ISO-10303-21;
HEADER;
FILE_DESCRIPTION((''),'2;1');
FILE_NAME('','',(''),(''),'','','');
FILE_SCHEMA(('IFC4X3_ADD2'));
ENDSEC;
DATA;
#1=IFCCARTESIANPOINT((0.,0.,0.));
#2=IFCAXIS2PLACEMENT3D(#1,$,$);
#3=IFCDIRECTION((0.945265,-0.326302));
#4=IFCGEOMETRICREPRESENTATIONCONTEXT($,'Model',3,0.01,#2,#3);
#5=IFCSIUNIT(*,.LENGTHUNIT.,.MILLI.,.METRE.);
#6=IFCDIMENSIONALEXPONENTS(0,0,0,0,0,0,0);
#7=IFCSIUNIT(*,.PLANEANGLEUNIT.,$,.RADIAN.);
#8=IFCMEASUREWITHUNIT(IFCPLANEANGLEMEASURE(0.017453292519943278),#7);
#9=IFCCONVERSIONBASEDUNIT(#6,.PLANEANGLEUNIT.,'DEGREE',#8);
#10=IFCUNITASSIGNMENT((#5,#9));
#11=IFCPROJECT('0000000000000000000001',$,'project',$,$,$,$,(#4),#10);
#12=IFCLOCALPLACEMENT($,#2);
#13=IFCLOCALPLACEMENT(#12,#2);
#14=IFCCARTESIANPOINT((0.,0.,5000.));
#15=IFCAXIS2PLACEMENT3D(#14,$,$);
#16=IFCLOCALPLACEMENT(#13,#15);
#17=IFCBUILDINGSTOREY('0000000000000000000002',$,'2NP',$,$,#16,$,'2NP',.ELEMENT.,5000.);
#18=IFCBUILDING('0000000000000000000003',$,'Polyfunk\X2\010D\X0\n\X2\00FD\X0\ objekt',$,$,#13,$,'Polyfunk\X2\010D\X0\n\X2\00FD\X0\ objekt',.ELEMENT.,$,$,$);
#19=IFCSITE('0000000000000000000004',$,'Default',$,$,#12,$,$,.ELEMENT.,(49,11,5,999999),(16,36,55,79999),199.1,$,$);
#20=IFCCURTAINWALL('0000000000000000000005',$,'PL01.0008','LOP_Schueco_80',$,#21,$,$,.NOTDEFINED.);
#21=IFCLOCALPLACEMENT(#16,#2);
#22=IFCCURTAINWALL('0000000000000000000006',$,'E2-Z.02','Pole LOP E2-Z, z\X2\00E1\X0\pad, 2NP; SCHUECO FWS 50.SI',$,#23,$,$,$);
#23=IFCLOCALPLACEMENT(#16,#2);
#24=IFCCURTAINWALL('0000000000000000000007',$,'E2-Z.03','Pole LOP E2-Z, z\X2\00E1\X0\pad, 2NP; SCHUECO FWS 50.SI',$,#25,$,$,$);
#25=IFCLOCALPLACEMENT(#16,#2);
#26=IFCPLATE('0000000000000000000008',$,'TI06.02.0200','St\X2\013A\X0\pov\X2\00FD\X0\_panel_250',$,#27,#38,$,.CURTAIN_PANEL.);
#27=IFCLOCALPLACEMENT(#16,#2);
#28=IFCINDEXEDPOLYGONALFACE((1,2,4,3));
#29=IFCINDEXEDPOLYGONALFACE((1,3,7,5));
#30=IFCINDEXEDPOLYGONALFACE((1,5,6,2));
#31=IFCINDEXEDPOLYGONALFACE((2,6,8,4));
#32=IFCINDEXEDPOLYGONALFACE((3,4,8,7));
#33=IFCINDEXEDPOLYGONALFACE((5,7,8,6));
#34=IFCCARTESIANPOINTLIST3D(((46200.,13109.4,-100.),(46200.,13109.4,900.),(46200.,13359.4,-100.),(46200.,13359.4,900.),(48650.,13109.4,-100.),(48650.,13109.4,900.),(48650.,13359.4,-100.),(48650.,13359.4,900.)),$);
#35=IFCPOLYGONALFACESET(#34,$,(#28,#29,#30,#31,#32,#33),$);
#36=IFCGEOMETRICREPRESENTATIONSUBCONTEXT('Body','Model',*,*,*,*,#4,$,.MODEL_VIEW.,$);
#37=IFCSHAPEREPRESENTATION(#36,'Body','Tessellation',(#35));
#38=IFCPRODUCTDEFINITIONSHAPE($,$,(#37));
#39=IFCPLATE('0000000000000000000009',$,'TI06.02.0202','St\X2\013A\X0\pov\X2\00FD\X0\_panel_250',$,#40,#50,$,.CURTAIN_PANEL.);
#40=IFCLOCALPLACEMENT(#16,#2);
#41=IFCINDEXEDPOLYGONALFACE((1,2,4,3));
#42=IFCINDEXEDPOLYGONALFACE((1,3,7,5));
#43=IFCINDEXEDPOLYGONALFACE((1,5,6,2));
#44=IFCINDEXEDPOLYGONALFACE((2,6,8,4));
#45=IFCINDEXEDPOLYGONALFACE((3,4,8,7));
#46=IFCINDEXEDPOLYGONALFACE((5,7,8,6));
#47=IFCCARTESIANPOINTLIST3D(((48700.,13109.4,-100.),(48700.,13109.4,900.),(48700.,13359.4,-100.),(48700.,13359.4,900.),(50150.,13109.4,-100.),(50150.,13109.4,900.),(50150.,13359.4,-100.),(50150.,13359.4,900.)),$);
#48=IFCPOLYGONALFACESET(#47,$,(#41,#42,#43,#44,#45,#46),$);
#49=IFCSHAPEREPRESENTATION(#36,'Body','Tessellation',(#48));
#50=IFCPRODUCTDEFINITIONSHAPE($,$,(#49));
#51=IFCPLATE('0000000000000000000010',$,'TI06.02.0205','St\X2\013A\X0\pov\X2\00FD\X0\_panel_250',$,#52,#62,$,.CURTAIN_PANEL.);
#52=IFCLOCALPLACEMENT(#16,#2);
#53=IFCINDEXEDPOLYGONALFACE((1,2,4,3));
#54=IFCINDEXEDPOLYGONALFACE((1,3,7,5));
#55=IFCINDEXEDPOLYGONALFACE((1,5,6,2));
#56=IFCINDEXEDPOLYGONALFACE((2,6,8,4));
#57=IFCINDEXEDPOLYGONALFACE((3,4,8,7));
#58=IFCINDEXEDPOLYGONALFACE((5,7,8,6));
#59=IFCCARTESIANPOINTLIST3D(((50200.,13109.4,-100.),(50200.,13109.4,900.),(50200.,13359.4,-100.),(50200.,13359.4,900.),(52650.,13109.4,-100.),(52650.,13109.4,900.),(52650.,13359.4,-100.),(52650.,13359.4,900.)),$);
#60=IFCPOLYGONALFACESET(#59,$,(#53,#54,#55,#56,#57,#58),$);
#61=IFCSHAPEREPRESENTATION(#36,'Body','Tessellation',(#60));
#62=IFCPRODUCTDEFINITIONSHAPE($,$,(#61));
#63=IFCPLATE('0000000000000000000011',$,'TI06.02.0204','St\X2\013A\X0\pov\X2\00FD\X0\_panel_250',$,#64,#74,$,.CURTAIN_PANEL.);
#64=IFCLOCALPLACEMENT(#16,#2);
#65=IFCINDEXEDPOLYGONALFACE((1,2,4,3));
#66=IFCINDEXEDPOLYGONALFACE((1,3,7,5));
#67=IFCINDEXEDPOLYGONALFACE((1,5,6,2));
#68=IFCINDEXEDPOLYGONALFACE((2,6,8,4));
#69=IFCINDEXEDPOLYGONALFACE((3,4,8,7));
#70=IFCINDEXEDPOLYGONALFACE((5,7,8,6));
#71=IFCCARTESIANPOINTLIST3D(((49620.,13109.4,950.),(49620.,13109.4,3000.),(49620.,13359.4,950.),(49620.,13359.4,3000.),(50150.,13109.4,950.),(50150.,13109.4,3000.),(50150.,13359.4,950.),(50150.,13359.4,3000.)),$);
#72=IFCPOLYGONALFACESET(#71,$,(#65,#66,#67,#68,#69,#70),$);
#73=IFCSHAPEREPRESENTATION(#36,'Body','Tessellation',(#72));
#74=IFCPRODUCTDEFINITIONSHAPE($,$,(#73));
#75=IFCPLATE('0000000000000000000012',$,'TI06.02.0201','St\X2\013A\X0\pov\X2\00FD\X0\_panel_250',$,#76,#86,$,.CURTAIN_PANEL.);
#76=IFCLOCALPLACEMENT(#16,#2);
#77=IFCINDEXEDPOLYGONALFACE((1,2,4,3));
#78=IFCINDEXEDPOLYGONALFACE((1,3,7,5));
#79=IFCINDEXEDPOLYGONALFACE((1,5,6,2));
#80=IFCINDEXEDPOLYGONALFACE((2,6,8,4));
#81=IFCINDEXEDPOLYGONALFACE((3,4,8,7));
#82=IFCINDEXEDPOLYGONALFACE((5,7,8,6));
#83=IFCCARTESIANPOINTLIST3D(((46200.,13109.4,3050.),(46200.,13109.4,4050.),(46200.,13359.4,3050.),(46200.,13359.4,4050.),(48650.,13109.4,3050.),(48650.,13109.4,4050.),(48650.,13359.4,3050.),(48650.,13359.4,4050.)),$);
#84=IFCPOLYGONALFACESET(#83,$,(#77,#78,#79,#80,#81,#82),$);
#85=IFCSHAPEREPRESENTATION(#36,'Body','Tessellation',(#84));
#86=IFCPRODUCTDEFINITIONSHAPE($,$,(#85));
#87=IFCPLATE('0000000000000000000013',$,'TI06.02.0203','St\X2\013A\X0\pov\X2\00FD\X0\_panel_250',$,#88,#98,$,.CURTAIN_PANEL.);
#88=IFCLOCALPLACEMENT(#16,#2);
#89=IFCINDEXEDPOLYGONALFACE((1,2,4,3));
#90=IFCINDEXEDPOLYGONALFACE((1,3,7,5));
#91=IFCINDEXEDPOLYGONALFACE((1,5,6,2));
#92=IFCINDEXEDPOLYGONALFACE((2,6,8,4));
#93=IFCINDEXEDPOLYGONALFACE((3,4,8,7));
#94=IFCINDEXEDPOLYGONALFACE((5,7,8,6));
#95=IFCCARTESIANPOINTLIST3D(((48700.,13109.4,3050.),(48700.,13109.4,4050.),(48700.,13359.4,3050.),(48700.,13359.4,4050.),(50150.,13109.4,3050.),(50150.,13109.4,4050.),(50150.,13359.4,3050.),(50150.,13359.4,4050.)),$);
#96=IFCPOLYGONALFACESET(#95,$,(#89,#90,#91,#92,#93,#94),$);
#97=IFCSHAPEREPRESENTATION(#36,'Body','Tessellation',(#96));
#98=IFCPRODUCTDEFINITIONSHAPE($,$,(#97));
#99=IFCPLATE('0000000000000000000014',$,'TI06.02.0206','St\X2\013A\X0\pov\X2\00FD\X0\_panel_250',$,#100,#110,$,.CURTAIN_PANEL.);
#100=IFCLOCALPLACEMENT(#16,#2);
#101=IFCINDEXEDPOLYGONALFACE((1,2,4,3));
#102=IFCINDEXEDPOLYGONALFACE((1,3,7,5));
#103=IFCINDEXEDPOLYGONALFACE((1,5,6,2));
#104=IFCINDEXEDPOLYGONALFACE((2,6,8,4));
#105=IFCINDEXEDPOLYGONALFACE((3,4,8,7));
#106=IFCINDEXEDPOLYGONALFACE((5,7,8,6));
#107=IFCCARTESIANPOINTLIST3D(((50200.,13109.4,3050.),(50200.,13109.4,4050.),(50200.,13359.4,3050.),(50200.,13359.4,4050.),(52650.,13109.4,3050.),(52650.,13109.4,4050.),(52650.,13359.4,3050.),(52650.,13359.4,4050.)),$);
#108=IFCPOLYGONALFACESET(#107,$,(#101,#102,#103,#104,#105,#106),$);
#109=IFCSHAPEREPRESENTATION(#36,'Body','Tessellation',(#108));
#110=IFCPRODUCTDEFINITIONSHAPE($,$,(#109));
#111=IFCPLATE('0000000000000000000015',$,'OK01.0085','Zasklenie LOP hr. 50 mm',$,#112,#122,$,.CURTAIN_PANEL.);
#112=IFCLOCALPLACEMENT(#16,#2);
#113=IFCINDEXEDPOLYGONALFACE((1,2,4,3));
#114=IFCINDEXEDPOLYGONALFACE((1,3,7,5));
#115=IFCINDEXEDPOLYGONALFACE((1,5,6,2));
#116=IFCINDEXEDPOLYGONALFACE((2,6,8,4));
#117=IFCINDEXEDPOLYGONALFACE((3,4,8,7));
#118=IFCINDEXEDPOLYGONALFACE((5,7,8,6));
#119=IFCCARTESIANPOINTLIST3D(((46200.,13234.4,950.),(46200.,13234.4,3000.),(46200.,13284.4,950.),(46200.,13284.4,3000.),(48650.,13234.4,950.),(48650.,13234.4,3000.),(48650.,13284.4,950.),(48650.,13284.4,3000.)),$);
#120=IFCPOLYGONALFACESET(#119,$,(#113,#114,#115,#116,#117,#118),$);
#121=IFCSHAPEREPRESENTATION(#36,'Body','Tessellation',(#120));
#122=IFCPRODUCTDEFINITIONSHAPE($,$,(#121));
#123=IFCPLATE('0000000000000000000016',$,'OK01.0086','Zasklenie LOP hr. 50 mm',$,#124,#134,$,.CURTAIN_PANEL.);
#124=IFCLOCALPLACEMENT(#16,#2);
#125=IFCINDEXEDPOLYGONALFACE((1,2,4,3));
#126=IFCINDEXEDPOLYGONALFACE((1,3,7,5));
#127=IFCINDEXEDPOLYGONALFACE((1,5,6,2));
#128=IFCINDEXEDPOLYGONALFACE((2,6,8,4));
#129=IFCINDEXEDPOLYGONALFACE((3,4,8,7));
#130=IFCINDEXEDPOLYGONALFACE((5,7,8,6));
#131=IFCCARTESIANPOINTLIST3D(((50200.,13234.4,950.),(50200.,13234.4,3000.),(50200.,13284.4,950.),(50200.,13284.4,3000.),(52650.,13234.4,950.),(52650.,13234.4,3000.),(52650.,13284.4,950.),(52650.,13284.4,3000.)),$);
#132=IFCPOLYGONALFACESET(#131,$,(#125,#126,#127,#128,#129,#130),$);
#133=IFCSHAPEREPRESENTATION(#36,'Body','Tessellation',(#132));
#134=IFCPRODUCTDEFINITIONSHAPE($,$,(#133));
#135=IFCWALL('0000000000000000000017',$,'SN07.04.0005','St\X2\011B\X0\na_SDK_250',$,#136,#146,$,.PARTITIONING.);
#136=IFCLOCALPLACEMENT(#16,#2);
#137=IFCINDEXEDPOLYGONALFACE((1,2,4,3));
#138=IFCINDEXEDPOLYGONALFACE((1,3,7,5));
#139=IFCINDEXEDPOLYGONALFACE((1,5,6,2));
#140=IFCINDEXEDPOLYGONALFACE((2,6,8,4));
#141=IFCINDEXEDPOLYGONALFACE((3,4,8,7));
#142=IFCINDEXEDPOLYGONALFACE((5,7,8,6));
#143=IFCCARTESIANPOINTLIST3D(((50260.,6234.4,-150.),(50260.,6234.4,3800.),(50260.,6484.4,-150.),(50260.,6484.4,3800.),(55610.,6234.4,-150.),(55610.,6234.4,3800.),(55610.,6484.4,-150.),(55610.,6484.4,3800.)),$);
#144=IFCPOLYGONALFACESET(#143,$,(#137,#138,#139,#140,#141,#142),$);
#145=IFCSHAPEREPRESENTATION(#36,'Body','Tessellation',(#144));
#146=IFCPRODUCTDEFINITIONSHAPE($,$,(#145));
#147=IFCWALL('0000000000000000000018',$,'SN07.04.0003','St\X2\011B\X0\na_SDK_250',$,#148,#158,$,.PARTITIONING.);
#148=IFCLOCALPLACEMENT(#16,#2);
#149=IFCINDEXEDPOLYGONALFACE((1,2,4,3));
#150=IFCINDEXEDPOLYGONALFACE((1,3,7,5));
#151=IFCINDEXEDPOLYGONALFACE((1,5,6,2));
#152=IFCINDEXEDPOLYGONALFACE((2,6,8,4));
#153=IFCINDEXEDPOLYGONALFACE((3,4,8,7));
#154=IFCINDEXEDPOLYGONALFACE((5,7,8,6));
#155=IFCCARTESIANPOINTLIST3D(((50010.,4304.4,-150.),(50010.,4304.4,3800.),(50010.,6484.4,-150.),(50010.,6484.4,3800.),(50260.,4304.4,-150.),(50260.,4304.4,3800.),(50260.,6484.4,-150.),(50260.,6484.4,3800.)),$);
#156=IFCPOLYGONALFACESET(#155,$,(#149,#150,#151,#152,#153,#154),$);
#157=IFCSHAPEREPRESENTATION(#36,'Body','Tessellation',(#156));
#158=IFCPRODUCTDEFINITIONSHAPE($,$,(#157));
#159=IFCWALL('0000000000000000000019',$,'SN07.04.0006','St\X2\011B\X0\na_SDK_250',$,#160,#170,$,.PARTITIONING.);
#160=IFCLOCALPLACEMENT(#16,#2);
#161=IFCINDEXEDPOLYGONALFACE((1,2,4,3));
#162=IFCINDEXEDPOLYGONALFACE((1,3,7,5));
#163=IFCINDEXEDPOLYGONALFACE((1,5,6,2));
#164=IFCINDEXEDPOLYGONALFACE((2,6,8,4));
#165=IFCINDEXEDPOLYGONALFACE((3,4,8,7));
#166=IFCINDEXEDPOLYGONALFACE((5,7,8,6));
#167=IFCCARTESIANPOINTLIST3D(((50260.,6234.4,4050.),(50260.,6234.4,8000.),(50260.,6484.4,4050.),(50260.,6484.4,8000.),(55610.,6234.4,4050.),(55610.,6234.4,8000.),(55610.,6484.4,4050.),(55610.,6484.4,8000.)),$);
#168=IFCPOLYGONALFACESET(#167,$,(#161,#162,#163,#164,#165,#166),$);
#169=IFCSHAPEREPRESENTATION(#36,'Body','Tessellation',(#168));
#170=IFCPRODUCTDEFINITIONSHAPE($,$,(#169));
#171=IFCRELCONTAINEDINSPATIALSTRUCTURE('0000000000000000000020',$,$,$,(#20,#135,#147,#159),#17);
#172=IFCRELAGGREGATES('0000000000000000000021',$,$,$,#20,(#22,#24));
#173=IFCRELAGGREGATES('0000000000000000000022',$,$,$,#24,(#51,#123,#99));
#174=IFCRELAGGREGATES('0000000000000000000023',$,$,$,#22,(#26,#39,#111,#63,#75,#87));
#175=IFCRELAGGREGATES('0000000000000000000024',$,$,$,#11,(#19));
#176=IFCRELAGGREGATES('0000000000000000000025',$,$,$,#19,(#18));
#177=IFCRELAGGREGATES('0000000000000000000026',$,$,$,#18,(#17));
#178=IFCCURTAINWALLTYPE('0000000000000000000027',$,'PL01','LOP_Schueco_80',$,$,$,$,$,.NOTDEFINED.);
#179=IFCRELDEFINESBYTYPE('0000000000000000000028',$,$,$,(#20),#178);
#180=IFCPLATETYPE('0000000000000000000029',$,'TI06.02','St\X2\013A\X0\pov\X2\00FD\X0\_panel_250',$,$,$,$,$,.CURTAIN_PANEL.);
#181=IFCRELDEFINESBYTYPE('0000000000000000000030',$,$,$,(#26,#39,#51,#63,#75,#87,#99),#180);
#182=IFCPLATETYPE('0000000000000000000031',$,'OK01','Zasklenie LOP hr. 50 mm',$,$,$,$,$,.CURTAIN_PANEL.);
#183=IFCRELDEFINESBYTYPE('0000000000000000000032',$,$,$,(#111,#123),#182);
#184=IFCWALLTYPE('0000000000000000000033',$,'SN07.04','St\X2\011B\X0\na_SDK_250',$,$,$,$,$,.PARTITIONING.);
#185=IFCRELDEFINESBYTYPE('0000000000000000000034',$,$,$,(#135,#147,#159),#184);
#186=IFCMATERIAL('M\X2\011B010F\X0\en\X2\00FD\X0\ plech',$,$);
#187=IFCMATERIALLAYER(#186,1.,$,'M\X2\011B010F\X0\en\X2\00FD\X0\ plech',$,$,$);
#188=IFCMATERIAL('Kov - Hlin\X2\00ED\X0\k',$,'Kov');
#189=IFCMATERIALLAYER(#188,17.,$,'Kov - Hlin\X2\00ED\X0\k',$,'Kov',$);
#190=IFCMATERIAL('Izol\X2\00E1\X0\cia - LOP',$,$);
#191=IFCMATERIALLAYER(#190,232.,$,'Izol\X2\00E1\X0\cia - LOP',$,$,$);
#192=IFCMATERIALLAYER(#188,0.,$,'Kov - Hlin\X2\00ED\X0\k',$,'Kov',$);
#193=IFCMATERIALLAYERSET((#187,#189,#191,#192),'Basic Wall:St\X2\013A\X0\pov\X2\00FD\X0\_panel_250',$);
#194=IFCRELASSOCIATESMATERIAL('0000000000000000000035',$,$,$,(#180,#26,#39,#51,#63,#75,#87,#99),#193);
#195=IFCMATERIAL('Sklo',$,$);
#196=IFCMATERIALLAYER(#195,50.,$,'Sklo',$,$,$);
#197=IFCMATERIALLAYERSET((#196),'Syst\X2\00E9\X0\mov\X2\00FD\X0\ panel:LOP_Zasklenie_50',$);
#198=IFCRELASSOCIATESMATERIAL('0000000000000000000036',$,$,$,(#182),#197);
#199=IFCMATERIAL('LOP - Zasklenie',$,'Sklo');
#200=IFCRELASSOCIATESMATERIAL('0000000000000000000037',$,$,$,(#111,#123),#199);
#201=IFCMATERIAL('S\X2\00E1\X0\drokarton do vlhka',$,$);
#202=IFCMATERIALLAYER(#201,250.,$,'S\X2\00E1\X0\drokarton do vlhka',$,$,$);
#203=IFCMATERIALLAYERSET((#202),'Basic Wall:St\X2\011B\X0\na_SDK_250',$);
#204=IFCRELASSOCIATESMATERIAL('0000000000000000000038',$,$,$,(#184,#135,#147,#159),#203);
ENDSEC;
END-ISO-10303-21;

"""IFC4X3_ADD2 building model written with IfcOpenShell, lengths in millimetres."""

from ifc_helpers import new_model, entity, si_unit, converted_unit, direction, frame, frame_2d, origin, origin_2d_with_axis, place, context, subcontext, project, spatial, polyline, rectangle, extrude, clip, bounded_halfspace, source, transform, mapped, material, layer, layer_set, layer_usage, type_object, type_shapes, element, aggregate, save


model = new_model("IFC4X3_ADD2")

# Units and contexts
model_context = context("Model", 3, precision=0.01, world=origin(), true_north=direction((0.945265, -0.326302)))
body_context = subcontext(model_context, "Body", "Model", "MODEL_VIEW")
ifc_project = project(units=[si_unit("LENGTHUNIT", "METRE", prefix="MILLI"), converted_unit("PLANEANGLEUNIT", "DEGREE", entity("IfcPlaneAngleMeasure", 0.017453292519943278), si_unit("PLANEANGLEUNIT", "RADIAN"), dimensions=[0, 0, 0, 0, 0, 0, 0])], contexts=[model_context])

# Site, building, storey
site_placement = place(None, origin())
site = spatial("IfcSite", under=ifc_project, at=site_placement, Name="Default", CompositionType="ELEMENT", RefLatitude=(49, 11, 5, 999999), RefLongitude=(16, 36, 55, 79999), RefElevation=199.1)
building_placement = place(site_placement, origin())
building = spatial("IfcBuilding", under=site, at=building_placement, Name="Polyfunkčný objekt", LongName="Polyfunkčný objekt", CompositionType="ELEMENT")
storey_placement = place(building_placement, frame((0.0, 0.0, 5000.0)))
storey = spatial("IfcBuildingStorey", under=building, at=storey_placement, Name="2NP", LongName="2NP", CompositionType="ELEMENT", Elevation=5000.0)

# Curtain walls, plates
curtain_wall_type = type_object("IfcCurtainWallType", Name="PL01", Description="LOP_Schueco_80", PredefinedType="NOTDEFINED")
curtain_wall_1_placement = place(storey_placement, frame((0.0, 0.0, -5000.0)))
curtain_wall_1 = element("IfcCurtainWall", 1, at=curtain_wall_1_placement, inside=storey, type_object=curtain_wall_type, Name="PL01.0008", Description="LOP_Schueco_80", PredefinedType="NOTDEFINED")
curtain_wall_2 = element("IfcCurtainWall", 2, Name="E2-Z.02", Description="Pole LOP E2-Z, západ, 2NP; SCHUECO FWS 50.SI")
curtain_wall_3 = element("IfcCurtainWall", 3, Name="E2-Z.03", Description="Pole LOP E2-Z, západ, 2NP; SCHUECO FWS 50.SI")
aggregate(curtain_wall_1, [curtain_wall_2, curtain_wall_3])
ifc_material_1 = material(Name="Měďený plech")
ifc_layer_1 = layer(ifc_material_1, 1.0, Name="Měďený plech")
ifc_material_2 = material(Name="Kov - Hliník", Category="Kov")
ifc_layer_2 = layer(ifc_material_2, 17.0, Name="Kov - Hliník", Category="Kov")
ifc_material_3 = material(Name="Izolácia - LOP")
ifc_layer_3 = layer(ifc_material_3, 232.0, Name="Izolácia - LOP")
ifc_layer_4 = layer(ifc_material_2, 0.0, Name="Kov - Hliník", Category="Kov")
ifc_layer_set_1 = layer_set([ifc_layer_1, ifc_layer_2, ifc_layer_3, ifc_layer_4], Name="Basic Wall:Stĺpový_panel_250")
ifc_layer_usage_1 = layer_usage(ifc_layer_set_1, "AXIS2", "NEGATIVE", 125.0)
plate_type_1 = type_object("IfcPlateType", Name="TI06.02", Description="Stĺpový_panel_250", PredefinedType="CURTAIN_PANEL", material=ifc_layer_set_1)
plate_1_placement = place(storey_placement, frame((46200.0, 13234.4, -100.0)))
plate_1 = element("IfcPlate", 4, at=plate_1_placement, type_object=plate_type_1, material=ifc_layer_usage_1, Name="TI06.02.0200", Description="Stĺpový_panel_250", PredefinedType="CURTAIN_PANEL", context=body_context, shape_type="SweptSolid", body=[
    extrude(rectangle(XDim=250.0, YDim=2450.0, at=frame_2d((0.0, 0.0), x_axis=(1.0, 0.0))), frame((1225.0, 0.0, 0.0), z_axis=(0.0, 0.0, 1.0), x_axis=(0.0, 1.0, 0.0)), (0.0, 0.0, 1.0), 1000.0),
])
ifc_layer_usage_2 = layer_usage(ifc_layer_set_1, "AXIS2", "NEGATIVE", 125.0)
plate_2_placement = place(storey_placement, frame((48700.0, 13234.4, -100.0)))
plate_2 = element("IfcPlate", 5, at=plate_2_placement, type_object=plate_type_1, material=ifc_layer_usage_2, Name="TI06.02.0202", Description="Stĺpový_panel_250", PredefinedType="CURTAIN_PANEL", context=body_context, shape_type="SweptSolid", body=[
    extrude(rectangle(XDim=250.0, YDim=1450.0, at=frame_2d((0.0, 0.0), x_axis=(1.0, 0.0))), frame((725.0, 0.0, 0.0), z_axis=(0.0, 0.0, 1.0), x_axis=(0.0, 1.0, 0.0)), (0.0, 0.0, 1.0), 1000.0),
])
ifc_layer_usage_3 = layer_usage(ifc_layer_set_1, "AXIS2", "NEGATIVE", 125.0)
plate_3_placement = place(storey_placement, frame((50200.0, 13234.4, -100.0)))
plate_3 = element("IfcPlate", 6, at=plate_3_placement, type_object=plate_type_1, material=ifc_layer_usage_3, Name="TI06.02.0205", Description="Stĺpový_panel_250", PredefinedType="CURTAIN_PANEL", context=body_context, shape_type="SweptSolid", body=[
    extrude(rectangle(XDim=250.0, YDim=2450.0, at=origin_2d_with_axis()), frame((1225.0, 0.0, 0.0), z_axis=(0.0, 0.0, 1.0), x_axis=(0.0, 1.0, 0.0)), (0.0, 0.0, 1.0), 1000.0),
])
ifc_layer_usage_4 = layer_usage(ifc_layer_set_1, "AXIS2", "NEGATIVE", 125.0)
plate_4_placement = place(storey_placement, frame((49620.0, 13234.4, 950.0)))
plate_4 = element("IfcPlate", 7, at=plate_4_placement, type_object=plate_type_1, material=ifc_layer_usage_4, Name="TI06.02.0204", Description="Stĺpový_panel_250", PredefinedType="CURTAIN_PANEL", context=body_context, shape_type="SweptSolid", body=[
    extrude(rectangle(XDim=250.0, YDim=530.0, at=frame_2d((0.0, 0.0), x_axis=(1.0, 0.0))), frame((265.0, 0.0, 0.0), z_axis=(0.0, 0.0, 1.0), x_axis=(0.0, 1.0, 0.0)), (0.0, 0.0, 1.0), 2050.0),
])
ifc_layer_usage_5 = layer_usage(ifc_layer_set_1, "AXIS2", "NEGATIVE", 125.0)
plate_5_placement = place(storey_placement, frame((46200.0, 13234.4, 3050.0)))
plate_5 = element("IfcPlate", 8, at=plate_5_placement, type_object=plate_type_1, material=ifc_layer_usage_5, Name="TI06.02.0201", Description="Stĺpový_panel_250", PredefinedType="CURTAIN_PANEL", context=body_context, shape_type="SweptSolid", body=[
    extrude(rectangle(XDim=250.0, YDim=2450.0, at=frame_2d((0.0, 0.0), x_axis=(1.0, 0.0))), frame((1225.0, 0.0, 0.0), z_axis=(0.0, 0.0, 1.0), x_axis=(0.0, 1.0, 0.0)), (0.0, 0.0, 1.0), 1000.0),
])
ifc_layer_usage_6 = layer_usage(ifc_layer_set_1, "AXIS2", "NEGATIVE", 125.0)
plate_6_placement = place(storey_placement, frame((48700.0, 13234.4, 3050.0)))
plate_6 = element("IfcPlate", 9, at=plate_6_placement, type_object=plate_type_1, material=ifc_layer_usage_6, Name="TI06.02.0203", Description="Stĺpový_panel_250", PredefinedType="CURTAIN_PANEL", context=body_context, shape_type="SweptSolid", body=[
    extrude(rectangle(XDim=250.0, YDim=1450.0, at=frame_2d((0.0, 0.0), x_axis=(1.0, 0.0))), frame((725.0, 0.0, 0.0), z_axis=(0.0, 0.0, 1.0), x_axis=(0.0, 1.0, 0.0)), (0.0, 0.0, 1.0), 1000.0),
])
ifc_layer_usage_7 = layer_usage(ifc_layer_set_1, "AXIS2", "NEGATIVE", 125.0)
plate_7_placement = place(storey_placement, frame((50200.0, 13234.4, 3050.0)))
plate_7 = element("IfcPlate", 10, at=plate_7_placement, type_object=plate_type_1, material=ifc_layer_usage_7, Name="TI06.02.0206", Description="Stĺpový_panel_250", PredefinedType="CURTAIN_PANEL", context=body_context, shape_type="SweptSolid", body=[
    extrude(rectangle(XDim=250.0, YDim=2450.0, at=origin_2d_with_axis()), frame((1225.0, 0.0, 0.0), z_axis=(0.0, 0.0, 1.0), x_axis=(0.0, 1.0, 0.0)), (0.0, 0.0, 1.0), 1000.0),
])
ifc_material_4 = material(Name="LOP - Zasklenie", Category="Sklo")
ifc_material_5 = material(Name="Sklo")
ifc_layer_5 = layer(ifc_material_5, 50.0, Name="Sklo")
ifc_layer_set_2 = layer_set([ifc_layer_5], Name="Systémový panel:LOP_Zasklenie_50")
plate_type_2 = type_object("IfcPlateType", Name="OK01", Description="Zasklenie LOP hr. 50 mm", PredefinedType="CURTAIN_PANEL", material=ifc_layer_set_2)
shared_shape_1 = source(origin(), body_context, "Body", "SweptSolid", [
    extrude(rectangle(XDim=50.0, YDim=2450.0, at=origin_2d_with_axis()), frame((0.0, 25.0, 0.0), z_axis=(0.0, 0.0, 1.0), x_axis=(0.0, 1.0, 0.0)), (0.0, 0.0, 1.0), 2050.0),
])
type_shapes(plate_type_2, [shared_shape_1])
plate_8_placement = place(curtain_wall_1_placement, frame((47425.0, 13234.4, 5950.0)))
plate_8 = element("IfcPlate", 11, at=plate_8_placement, type_object=plate_type_2, material=ifc_material_4, Name="OK01.0085", Description="Zasklenie LOP hr. 50 mm", PredefinedType="CURTAIN_PANEL", context=body_context, shape_type="MappedRepresentation", body=[
    mapped(shared_shape_1, transform((0.0, 0.0, 0.0), scale=1.0)),
])
plate_9_placement = place(curtain_wall_1_placement, frame((51425.0, 13234.4, 5950.0)))
plate_9 = element("IfcPlate", 12, at=plate_9_placement, type_object=plate_type_2, material=ifc_material_4, Name="OK01.0086", Description="Zasklenie LOP hr. 50 mm", PredefinedType="CURTAIN_PANEL", context=body_context, shape_type="MappedRepresentation", body=[
    mapped(shared_shape_1, transform((0.0, 0.0, 0.0), scale=1.0)),
])
aggregate(curtain_wall_3, [plate_3, plate_9, plate_7])

# Walls
ifc_material_6 = material(Name="Sádrokarton do vlhka")
ifc_layer_6 = layer(ifc_material_6, 250.0, Name="Sádrokarton do vlhka")
ifc_layer_set_3 = layer_set([ifc_layer_6], Name="Basic Wall:Stěna_SDK_250")
wall_type_1 = type_object("IfcWallType", Name="SN07.04", Description="Stěna_SDK_250", PredefinedType="PARTITIONING", material=ifc_layer_set_3)
wall_1_placement = place(storey_placement, frame((50260.0, 6359.4, -150.0)))
element("IfcWall", 13, at=wall_1_placement, inside=storey, type_object=wall_type_1, material=ifc_layer_set_3, Name="SN07.04.0005", Description="Stěna_SDK_250", PredefinedType="PARTITIONING", context=body_context, shape_type="Clipping", body=[
    clip(clip(extrude(rectangle(XDim=5350.0, YDim=250.0, at=frame_2d((2675.0, 0.0), x_axis=(-1.0, 0.0))), origin(), (0.0, 0.0, 1.0), 3950.0), bounded_halfspace(frame((5350.0, -125.0, 0.0), z_axis=(0.0, 0.0, 1.0), x_axis=(-1.0, 0.0, 0.0)), True, frame((5350.0, -125.0, 0.0)), polyline([(0.0, 0.0), (0.0, 250.0), (-5350.0, 250.0), (-5350.0, 0.0), (-1670.0, 0.0), (-1520.0, 0.0), (0.0, 0.0)]))), bounded_halfspace(frame((0.0, -125.0, 3950.0), z_axis=(0.0, 0.0, -1.0), x_axis=(1.0, 0.0, 0.0)), True, frame((0.0, -125.0, 3950.0)), polyline([(0.0, 0.0), (3680.0, 0.0), (3830.0, 0.0), (5350.0, 0.0), (5350.0, 250.0), (0.0, 250.0), (0.0, 0.0)]))),
])
wall_2_placement = place(storey_placement, frame((50135.0, 6484.4, -150.0), z_axis=(0.0, 0.0, 1.0), x_axis=(0.0, -1.0, 0.0)))
element("IfcWall", 14, at=wall_2_placement, inside=storey, type_object=wall_type_1, material=ifc_layer_set_3, Name="SN07.04.0003", Description="Stěna_SDK_250", PredefinedType="PARTITIONING", context=body_context, shape_type="Clipping", body=[
    clip(clip(extrude(rectangle(XDim=2180.0, YDim=250.0, at=frame_2d((1090.0, 0.0), x_axis=(-1.0, 0.0))), origin(), (0.0, 0.0, 1.0), 3950.0), bounded_halfspace(frame((2180.0, -125.0, 0.0), z_axis=(0.0, 0.0, 1.0), x_axis=(0.0, -1.0, 0.0)), True, frame((2180.0, -125.0, 0.0)), polyline([(0.0, 0.0), (0.0, 250.0), (-1930.0, 250.0), (-2180.0, 250.0), (-2180.0, 0.0), (0.0, 0.0)]))), bounded_halfspace(frame((0.0, -125.0, 3950.0), z_axis=(0.0, 0.0, -1.0), x_axis=(0.0, 1.0, 0.0)), True, frame((0.0, -125.0, 3950.0)), polyline([(0.0, 0.0), (2180.0, 0.0), (2180.0, 250.0), (250.0, 250.0), (0.0, 250.0), (0.0, 0.0)]))),
])
wall_3_placement = place(storey_placement, frame((50260.0, 6359.4, 4050.0)))
element("IfcWall", 15, at=wall_3_placement, inside=storey, type_object=wall_type_1, material=ifc_layer_set_3, Name="SN07.04.0006", Description="Stěna_SDK_250", PredefinedType="PARTITIONING", context=body_context, shape_type="Clipping", body=[
    clip(clip(extrude(rectangle(XDim=5350.0, YDim=250.0, at=frame_2d((2675.0, 0.0), x_axis=(-1.0, 0.0))), origin(), (0.0, 0.0, 1.0), 3950.0), bounded_halfspace(frame((5350.0, -125.0, 0.0), z_axis=(0.0, 0.0, 1.0), x_axis=(-1.0, 0.0, 0.0)), True, frame((5350.0, -125.0, 0.0)), polyline([(0.0, 0.0), (0.0, 250.0), (-5350.0, 250.0), (-5350.0, 0.0), (-1670.0, 0.0), (-1520.0, 0.0), (0.0, 0.0)]))), bounded_halfspace(frame((0.0, -125.0, 3950.0), z_axis=(0.0, 0.0, -1.0), x_axis=(1.0, 0.0, 0.0)), True, frame((0.0, -125.0, 3950.0)), polyline([(0.0, 0.0), (3680.0, 0.0), (3830.0, 0.0), (5350.0, 0.0), (5350.0, 250.0), (0.0, 250.0), (0.0, 0.0)]))),
])

aggregate(curtain_wall_2, [plate_1, plate_2, plate_8, plate_4, plate_5, plate_6])

save(model, "model.ifc")
